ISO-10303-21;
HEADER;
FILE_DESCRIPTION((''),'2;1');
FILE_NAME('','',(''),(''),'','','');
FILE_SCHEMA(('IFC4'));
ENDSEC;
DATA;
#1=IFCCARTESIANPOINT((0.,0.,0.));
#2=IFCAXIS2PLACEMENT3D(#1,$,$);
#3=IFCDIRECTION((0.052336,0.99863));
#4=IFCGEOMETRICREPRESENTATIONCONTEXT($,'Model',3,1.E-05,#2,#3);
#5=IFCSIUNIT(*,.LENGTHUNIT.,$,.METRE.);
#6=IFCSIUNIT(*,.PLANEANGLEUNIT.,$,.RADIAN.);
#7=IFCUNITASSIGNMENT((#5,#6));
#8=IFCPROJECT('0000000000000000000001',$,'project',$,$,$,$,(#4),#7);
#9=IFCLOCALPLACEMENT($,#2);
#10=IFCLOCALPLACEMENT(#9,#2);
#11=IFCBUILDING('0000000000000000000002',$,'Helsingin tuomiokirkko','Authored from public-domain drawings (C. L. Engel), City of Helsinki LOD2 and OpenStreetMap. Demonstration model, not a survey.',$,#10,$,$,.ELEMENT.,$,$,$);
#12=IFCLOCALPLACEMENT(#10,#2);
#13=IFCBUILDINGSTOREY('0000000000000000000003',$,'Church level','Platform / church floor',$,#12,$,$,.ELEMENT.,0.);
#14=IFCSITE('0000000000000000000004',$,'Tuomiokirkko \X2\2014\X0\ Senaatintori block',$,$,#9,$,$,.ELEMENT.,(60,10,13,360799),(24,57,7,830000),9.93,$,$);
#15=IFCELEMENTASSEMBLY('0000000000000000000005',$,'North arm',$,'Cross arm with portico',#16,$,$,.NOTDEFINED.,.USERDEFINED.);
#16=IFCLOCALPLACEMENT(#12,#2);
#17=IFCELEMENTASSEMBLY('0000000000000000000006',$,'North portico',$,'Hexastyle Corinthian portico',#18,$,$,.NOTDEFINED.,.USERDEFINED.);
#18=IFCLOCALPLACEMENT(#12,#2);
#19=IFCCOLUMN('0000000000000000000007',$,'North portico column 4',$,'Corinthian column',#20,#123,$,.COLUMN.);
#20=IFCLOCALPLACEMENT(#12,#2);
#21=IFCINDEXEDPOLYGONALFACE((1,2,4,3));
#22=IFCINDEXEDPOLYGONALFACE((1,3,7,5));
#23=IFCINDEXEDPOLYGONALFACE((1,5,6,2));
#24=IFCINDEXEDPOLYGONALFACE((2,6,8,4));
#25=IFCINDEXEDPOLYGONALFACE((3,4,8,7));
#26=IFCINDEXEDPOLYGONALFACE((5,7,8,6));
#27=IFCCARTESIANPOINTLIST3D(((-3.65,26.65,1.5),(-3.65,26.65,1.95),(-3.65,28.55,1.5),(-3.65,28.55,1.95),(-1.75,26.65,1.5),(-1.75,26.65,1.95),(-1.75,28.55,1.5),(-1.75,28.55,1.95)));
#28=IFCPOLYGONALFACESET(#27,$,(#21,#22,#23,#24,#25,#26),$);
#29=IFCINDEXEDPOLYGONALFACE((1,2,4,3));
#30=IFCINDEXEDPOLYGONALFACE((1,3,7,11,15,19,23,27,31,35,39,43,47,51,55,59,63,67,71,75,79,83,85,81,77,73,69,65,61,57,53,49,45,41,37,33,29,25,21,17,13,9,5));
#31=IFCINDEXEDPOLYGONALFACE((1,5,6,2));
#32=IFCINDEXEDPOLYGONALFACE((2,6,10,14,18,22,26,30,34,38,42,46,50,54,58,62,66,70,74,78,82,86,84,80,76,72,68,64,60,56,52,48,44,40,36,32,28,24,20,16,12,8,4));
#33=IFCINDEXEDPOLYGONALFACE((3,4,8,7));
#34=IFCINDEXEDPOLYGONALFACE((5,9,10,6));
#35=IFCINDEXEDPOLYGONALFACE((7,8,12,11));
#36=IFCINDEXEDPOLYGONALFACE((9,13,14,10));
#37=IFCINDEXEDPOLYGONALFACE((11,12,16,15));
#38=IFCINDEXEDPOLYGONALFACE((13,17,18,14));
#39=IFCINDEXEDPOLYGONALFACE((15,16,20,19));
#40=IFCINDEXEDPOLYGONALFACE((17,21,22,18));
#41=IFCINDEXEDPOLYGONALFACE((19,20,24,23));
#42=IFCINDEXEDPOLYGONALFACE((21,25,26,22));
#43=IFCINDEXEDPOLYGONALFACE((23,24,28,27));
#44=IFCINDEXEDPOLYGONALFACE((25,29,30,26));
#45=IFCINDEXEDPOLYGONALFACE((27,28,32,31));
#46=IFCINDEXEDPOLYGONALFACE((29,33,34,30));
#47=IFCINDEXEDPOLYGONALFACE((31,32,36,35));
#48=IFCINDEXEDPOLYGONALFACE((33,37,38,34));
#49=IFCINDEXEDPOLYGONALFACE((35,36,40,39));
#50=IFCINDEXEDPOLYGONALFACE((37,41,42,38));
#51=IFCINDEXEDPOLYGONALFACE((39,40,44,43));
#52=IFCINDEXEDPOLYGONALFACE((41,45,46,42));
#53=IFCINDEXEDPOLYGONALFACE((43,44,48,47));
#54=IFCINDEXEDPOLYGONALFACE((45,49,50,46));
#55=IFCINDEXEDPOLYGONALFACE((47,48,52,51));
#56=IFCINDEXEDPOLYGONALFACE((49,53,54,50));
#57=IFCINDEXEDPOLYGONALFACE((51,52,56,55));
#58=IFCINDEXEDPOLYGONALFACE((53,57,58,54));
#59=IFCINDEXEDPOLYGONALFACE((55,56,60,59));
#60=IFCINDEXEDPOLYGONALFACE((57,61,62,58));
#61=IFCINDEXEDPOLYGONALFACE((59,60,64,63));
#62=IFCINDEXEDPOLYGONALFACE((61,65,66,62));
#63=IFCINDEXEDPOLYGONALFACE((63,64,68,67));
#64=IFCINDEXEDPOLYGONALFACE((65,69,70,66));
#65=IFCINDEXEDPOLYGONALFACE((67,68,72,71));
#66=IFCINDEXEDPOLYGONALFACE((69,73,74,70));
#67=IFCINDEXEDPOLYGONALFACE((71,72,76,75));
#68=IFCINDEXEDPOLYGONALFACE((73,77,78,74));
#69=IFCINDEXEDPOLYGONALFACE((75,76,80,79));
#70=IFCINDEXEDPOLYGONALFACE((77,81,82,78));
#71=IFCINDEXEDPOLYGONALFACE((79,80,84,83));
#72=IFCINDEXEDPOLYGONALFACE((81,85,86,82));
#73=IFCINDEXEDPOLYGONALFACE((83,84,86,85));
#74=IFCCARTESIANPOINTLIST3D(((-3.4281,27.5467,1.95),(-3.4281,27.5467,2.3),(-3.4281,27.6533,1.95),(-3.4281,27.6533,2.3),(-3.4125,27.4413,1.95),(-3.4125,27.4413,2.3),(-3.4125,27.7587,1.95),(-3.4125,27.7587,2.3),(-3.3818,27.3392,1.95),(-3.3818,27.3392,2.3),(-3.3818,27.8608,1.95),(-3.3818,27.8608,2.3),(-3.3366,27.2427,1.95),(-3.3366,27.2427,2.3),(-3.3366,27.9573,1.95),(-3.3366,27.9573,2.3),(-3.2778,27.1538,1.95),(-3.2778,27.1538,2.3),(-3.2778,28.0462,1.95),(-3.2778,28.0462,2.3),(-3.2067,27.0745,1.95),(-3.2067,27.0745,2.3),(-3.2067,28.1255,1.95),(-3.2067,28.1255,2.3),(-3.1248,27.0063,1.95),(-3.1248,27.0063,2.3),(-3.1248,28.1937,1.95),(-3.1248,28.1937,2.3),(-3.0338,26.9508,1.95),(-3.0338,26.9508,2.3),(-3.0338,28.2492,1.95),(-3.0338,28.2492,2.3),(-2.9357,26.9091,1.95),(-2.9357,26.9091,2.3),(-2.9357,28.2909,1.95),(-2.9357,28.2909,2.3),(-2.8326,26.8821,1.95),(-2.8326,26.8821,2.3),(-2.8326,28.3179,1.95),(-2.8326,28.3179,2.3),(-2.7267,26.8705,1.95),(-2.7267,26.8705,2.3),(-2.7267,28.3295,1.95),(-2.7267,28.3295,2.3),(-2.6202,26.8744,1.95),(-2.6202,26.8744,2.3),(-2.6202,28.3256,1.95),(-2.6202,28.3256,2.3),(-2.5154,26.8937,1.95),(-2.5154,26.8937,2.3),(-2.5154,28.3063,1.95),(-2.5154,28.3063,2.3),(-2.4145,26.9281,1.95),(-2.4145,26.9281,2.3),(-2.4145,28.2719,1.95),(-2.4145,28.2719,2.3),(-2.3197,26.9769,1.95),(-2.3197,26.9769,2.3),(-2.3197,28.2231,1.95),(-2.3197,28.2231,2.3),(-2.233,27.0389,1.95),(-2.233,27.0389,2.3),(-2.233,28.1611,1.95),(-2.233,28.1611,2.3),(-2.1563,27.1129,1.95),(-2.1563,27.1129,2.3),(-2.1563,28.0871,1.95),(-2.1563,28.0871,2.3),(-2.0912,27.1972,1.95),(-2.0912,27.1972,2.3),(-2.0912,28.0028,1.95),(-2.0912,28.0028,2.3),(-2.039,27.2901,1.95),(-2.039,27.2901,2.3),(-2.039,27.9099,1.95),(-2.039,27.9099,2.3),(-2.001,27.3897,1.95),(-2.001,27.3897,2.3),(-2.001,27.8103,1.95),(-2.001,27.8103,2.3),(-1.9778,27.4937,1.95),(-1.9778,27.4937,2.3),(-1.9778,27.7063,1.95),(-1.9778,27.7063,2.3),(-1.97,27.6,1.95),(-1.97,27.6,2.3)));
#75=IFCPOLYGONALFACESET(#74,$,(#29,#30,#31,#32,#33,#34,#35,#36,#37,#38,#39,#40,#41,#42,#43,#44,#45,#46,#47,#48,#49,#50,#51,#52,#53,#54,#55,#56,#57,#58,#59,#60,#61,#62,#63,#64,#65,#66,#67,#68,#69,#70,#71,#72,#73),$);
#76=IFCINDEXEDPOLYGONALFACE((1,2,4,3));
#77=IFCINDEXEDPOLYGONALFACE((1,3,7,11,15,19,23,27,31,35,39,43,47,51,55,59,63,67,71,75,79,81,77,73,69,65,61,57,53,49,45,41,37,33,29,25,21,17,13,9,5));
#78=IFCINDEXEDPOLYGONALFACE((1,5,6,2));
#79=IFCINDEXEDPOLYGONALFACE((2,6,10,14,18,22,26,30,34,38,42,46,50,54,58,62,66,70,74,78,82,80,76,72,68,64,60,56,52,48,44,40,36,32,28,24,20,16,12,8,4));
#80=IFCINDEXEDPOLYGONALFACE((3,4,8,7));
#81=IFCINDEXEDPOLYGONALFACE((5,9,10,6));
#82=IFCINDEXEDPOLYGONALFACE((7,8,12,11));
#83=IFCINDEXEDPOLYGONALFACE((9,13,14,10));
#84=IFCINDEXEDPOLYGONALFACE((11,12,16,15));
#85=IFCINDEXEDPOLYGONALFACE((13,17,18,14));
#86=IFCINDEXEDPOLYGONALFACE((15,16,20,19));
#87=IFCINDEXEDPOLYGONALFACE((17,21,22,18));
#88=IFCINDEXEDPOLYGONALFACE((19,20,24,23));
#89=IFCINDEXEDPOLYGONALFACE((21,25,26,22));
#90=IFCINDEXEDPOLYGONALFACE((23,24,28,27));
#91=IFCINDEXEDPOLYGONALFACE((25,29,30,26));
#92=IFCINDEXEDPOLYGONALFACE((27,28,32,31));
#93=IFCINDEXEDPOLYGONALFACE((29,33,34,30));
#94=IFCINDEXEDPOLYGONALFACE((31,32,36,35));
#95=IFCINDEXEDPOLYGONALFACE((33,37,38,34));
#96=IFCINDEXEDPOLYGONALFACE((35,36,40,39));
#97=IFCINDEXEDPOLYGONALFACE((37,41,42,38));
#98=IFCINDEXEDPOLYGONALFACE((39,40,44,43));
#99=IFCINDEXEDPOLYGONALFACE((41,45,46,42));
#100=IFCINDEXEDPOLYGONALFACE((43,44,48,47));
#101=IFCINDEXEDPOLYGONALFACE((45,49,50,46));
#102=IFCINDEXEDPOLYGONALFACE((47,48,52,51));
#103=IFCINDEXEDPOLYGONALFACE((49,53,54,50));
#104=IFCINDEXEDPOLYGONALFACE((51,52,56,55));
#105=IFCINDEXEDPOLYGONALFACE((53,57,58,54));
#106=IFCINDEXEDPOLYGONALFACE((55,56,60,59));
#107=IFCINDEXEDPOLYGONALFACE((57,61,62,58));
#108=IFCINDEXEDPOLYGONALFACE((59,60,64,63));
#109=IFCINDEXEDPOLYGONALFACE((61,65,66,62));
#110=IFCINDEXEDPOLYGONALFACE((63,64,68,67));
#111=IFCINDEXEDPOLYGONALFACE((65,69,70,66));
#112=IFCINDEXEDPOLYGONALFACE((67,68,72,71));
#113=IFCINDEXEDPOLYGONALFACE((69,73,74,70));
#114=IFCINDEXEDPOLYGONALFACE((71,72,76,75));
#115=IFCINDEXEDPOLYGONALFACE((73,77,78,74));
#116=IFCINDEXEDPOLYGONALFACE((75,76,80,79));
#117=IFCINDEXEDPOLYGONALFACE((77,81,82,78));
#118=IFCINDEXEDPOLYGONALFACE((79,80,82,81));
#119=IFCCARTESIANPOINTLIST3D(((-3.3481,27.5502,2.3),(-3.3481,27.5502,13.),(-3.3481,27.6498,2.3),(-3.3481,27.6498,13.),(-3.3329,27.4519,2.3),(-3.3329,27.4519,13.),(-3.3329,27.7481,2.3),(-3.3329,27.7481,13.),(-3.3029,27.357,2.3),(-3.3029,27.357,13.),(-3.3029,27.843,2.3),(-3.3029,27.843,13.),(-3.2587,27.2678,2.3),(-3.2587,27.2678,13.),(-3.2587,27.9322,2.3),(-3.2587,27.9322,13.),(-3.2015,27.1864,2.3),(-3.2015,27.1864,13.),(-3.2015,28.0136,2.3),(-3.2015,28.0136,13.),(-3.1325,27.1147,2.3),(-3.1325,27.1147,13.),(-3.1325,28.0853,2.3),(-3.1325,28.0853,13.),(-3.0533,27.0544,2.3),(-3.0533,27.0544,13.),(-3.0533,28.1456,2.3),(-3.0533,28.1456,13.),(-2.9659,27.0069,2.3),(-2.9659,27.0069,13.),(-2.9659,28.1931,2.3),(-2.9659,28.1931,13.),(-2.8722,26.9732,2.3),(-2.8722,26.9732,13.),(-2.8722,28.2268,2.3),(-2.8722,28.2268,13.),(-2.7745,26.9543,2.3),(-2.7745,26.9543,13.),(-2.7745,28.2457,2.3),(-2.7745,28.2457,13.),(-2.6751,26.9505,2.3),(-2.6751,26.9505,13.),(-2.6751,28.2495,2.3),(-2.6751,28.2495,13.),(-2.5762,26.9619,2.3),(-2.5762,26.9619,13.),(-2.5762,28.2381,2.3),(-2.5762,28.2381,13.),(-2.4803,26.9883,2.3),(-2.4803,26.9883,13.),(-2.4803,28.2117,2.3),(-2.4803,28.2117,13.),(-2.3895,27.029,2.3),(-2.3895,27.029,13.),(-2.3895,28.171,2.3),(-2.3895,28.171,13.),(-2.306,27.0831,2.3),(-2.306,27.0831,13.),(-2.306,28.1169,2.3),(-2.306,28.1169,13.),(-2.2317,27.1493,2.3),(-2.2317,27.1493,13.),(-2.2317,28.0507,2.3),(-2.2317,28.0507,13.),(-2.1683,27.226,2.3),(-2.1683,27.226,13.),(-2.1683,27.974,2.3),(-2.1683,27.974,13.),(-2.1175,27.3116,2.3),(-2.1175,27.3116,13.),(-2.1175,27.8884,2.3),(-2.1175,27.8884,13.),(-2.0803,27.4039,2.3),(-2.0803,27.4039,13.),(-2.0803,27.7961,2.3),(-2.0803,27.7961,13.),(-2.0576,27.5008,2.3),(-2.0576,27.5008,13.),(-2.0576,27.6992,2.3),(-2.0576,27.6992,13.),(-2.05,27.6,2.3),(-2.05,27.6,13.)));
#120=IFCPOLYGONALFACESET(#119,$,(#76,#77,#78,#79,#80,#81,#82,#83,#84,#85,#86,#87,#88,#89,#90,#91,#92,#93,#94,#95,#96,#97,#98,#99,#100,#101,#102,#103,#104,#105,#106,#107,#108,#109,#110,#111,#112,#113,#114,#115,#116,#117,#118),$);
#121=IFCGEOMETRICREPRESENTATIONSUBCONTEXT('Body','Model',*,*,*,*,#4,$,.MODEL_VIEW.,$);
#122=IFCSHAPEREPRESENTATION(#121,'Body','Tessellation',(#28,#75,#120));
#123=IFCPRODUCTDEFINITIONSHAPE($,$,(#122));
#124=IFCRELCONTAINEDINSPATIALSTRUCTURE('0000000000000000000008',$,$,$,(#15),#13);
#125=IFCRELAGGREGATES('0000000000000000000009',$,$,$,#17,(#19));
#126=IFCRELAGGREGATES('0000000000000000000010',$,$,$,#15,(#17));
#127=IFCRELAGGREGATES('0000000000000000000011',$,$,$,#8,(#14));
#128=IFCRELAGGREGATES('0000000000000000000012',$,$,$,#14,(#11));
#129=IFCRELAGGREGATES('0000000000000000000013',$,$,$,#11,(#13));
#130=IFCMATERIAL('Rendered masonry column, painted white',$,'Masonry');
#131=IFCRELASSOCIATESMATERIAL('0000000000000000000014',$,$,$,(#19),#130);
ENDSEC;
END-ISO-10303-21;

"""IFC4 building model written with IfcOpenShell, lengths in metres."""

from ifc_helpers import new_model, si_unit, direction, frame, origin, origin_2d_with_axis, place, context, subcontext, project, spatial, rectangle, circle, extrude, material, element, aggregate, save


model = new_model("IFC4")

# Units and contexts
model_context = context("Model", 3, precision=1e-05, world=origin(), true_north=direction((0.052336, 0.99863)))
body_context = subcontext(model_context, "Body", "Model", "MODEL_VIEW")
ifc_project = project(units=[si_unit("LENGTHUNIT", "METRE"), si_unit("PLANEANGLEUNIT", "RADIAN")], contexts=[model_context])

# Site, building, storey
site_placement = place(None, origin())
site = spatial("IfcSite", under=ifc_project, at=site_placement, Name="Tuomiokirkko — Senaatintori block", CompositionType="ELEMENT", RefLatitude=(60, 10, 13, 360799), RefLongitude=(24, 57, 7, 830000), RefElevation=9.93)
building_placement = place(site_placement, origin())
building = spatial("IfcBuilding", under=site, at=building_placement, Name="Helsingin tuomiokirkko", Description="Authored from public-domain drawings (C. L. Engel), City of Helsinki LOD2 and OpenStreetMap. Demonstration model, not a survey.", CompositionType="ELEMENT")
storey_placement = place(building_placement, origin())
storey = spatial("IfcBuildingStorey", under=building, at=storey_placement, Name="Church level", Description="Platform / church floor", CompositionType="ELEMENT", Elevation=0.0)

# Element assemblies, column
ifc_material_1 = material(Name="Rendered masonry column, painted white", Category="Masonry")
assembly_1_placement = place(building_placement, origin())
assembly_1 = element("IfcElementAssembly", 1, at=assembly_1_placement, inside=storey, Name="North arm", ObjectType="Cross arm with portico", AssemblyPlace="NOTDEFINED", PredefinedType="USERDEFINED")
assembly_2_placement = place(building_placement, origin())
assembly_2 = element("IfcElementAssembly", 2, at=assembly_2_placement, Name="North portico", ObjectType="Hexastyle Corinthian portico", AssemblyPlace="NOTDEFINED", PredefinedType="USERDEFINED")
column_1_placement = place(building_placement, origin())
column_1 = element("IfcColumn", 3, at=column_1_placement, material=ifc_material_1, Name="North portico column 4", ObjectType="Corinthian column", PredefinedType="COLUMN", context=body_context, shape_type="SweptSolid", body=[
    extrude(rectangle(XDim=1.9, YDim=1.9, at=origin_2d_with_axis()), frame((-2.7, 27.6, 1.5)), (0.0, 0.0, 1.0), 0.45),
    extrude(circle(Radius=0.73, at=origin_2d_with_axis()), frame((-2.7, 27.6, 1.95)), (0.0, 0.0, 1.0), 0.35),
    extrude(circle(Radius=0.65, at=origin_2d_with_axis()), frame((-2.7, 27.6, 2.3)), (0.0, 0.0, 1.0), 10.7),
])

aggregate(assembly_2, [column_1])

aggregate(assembly_1, [assembly_2])

save(model, "model.ifc")
